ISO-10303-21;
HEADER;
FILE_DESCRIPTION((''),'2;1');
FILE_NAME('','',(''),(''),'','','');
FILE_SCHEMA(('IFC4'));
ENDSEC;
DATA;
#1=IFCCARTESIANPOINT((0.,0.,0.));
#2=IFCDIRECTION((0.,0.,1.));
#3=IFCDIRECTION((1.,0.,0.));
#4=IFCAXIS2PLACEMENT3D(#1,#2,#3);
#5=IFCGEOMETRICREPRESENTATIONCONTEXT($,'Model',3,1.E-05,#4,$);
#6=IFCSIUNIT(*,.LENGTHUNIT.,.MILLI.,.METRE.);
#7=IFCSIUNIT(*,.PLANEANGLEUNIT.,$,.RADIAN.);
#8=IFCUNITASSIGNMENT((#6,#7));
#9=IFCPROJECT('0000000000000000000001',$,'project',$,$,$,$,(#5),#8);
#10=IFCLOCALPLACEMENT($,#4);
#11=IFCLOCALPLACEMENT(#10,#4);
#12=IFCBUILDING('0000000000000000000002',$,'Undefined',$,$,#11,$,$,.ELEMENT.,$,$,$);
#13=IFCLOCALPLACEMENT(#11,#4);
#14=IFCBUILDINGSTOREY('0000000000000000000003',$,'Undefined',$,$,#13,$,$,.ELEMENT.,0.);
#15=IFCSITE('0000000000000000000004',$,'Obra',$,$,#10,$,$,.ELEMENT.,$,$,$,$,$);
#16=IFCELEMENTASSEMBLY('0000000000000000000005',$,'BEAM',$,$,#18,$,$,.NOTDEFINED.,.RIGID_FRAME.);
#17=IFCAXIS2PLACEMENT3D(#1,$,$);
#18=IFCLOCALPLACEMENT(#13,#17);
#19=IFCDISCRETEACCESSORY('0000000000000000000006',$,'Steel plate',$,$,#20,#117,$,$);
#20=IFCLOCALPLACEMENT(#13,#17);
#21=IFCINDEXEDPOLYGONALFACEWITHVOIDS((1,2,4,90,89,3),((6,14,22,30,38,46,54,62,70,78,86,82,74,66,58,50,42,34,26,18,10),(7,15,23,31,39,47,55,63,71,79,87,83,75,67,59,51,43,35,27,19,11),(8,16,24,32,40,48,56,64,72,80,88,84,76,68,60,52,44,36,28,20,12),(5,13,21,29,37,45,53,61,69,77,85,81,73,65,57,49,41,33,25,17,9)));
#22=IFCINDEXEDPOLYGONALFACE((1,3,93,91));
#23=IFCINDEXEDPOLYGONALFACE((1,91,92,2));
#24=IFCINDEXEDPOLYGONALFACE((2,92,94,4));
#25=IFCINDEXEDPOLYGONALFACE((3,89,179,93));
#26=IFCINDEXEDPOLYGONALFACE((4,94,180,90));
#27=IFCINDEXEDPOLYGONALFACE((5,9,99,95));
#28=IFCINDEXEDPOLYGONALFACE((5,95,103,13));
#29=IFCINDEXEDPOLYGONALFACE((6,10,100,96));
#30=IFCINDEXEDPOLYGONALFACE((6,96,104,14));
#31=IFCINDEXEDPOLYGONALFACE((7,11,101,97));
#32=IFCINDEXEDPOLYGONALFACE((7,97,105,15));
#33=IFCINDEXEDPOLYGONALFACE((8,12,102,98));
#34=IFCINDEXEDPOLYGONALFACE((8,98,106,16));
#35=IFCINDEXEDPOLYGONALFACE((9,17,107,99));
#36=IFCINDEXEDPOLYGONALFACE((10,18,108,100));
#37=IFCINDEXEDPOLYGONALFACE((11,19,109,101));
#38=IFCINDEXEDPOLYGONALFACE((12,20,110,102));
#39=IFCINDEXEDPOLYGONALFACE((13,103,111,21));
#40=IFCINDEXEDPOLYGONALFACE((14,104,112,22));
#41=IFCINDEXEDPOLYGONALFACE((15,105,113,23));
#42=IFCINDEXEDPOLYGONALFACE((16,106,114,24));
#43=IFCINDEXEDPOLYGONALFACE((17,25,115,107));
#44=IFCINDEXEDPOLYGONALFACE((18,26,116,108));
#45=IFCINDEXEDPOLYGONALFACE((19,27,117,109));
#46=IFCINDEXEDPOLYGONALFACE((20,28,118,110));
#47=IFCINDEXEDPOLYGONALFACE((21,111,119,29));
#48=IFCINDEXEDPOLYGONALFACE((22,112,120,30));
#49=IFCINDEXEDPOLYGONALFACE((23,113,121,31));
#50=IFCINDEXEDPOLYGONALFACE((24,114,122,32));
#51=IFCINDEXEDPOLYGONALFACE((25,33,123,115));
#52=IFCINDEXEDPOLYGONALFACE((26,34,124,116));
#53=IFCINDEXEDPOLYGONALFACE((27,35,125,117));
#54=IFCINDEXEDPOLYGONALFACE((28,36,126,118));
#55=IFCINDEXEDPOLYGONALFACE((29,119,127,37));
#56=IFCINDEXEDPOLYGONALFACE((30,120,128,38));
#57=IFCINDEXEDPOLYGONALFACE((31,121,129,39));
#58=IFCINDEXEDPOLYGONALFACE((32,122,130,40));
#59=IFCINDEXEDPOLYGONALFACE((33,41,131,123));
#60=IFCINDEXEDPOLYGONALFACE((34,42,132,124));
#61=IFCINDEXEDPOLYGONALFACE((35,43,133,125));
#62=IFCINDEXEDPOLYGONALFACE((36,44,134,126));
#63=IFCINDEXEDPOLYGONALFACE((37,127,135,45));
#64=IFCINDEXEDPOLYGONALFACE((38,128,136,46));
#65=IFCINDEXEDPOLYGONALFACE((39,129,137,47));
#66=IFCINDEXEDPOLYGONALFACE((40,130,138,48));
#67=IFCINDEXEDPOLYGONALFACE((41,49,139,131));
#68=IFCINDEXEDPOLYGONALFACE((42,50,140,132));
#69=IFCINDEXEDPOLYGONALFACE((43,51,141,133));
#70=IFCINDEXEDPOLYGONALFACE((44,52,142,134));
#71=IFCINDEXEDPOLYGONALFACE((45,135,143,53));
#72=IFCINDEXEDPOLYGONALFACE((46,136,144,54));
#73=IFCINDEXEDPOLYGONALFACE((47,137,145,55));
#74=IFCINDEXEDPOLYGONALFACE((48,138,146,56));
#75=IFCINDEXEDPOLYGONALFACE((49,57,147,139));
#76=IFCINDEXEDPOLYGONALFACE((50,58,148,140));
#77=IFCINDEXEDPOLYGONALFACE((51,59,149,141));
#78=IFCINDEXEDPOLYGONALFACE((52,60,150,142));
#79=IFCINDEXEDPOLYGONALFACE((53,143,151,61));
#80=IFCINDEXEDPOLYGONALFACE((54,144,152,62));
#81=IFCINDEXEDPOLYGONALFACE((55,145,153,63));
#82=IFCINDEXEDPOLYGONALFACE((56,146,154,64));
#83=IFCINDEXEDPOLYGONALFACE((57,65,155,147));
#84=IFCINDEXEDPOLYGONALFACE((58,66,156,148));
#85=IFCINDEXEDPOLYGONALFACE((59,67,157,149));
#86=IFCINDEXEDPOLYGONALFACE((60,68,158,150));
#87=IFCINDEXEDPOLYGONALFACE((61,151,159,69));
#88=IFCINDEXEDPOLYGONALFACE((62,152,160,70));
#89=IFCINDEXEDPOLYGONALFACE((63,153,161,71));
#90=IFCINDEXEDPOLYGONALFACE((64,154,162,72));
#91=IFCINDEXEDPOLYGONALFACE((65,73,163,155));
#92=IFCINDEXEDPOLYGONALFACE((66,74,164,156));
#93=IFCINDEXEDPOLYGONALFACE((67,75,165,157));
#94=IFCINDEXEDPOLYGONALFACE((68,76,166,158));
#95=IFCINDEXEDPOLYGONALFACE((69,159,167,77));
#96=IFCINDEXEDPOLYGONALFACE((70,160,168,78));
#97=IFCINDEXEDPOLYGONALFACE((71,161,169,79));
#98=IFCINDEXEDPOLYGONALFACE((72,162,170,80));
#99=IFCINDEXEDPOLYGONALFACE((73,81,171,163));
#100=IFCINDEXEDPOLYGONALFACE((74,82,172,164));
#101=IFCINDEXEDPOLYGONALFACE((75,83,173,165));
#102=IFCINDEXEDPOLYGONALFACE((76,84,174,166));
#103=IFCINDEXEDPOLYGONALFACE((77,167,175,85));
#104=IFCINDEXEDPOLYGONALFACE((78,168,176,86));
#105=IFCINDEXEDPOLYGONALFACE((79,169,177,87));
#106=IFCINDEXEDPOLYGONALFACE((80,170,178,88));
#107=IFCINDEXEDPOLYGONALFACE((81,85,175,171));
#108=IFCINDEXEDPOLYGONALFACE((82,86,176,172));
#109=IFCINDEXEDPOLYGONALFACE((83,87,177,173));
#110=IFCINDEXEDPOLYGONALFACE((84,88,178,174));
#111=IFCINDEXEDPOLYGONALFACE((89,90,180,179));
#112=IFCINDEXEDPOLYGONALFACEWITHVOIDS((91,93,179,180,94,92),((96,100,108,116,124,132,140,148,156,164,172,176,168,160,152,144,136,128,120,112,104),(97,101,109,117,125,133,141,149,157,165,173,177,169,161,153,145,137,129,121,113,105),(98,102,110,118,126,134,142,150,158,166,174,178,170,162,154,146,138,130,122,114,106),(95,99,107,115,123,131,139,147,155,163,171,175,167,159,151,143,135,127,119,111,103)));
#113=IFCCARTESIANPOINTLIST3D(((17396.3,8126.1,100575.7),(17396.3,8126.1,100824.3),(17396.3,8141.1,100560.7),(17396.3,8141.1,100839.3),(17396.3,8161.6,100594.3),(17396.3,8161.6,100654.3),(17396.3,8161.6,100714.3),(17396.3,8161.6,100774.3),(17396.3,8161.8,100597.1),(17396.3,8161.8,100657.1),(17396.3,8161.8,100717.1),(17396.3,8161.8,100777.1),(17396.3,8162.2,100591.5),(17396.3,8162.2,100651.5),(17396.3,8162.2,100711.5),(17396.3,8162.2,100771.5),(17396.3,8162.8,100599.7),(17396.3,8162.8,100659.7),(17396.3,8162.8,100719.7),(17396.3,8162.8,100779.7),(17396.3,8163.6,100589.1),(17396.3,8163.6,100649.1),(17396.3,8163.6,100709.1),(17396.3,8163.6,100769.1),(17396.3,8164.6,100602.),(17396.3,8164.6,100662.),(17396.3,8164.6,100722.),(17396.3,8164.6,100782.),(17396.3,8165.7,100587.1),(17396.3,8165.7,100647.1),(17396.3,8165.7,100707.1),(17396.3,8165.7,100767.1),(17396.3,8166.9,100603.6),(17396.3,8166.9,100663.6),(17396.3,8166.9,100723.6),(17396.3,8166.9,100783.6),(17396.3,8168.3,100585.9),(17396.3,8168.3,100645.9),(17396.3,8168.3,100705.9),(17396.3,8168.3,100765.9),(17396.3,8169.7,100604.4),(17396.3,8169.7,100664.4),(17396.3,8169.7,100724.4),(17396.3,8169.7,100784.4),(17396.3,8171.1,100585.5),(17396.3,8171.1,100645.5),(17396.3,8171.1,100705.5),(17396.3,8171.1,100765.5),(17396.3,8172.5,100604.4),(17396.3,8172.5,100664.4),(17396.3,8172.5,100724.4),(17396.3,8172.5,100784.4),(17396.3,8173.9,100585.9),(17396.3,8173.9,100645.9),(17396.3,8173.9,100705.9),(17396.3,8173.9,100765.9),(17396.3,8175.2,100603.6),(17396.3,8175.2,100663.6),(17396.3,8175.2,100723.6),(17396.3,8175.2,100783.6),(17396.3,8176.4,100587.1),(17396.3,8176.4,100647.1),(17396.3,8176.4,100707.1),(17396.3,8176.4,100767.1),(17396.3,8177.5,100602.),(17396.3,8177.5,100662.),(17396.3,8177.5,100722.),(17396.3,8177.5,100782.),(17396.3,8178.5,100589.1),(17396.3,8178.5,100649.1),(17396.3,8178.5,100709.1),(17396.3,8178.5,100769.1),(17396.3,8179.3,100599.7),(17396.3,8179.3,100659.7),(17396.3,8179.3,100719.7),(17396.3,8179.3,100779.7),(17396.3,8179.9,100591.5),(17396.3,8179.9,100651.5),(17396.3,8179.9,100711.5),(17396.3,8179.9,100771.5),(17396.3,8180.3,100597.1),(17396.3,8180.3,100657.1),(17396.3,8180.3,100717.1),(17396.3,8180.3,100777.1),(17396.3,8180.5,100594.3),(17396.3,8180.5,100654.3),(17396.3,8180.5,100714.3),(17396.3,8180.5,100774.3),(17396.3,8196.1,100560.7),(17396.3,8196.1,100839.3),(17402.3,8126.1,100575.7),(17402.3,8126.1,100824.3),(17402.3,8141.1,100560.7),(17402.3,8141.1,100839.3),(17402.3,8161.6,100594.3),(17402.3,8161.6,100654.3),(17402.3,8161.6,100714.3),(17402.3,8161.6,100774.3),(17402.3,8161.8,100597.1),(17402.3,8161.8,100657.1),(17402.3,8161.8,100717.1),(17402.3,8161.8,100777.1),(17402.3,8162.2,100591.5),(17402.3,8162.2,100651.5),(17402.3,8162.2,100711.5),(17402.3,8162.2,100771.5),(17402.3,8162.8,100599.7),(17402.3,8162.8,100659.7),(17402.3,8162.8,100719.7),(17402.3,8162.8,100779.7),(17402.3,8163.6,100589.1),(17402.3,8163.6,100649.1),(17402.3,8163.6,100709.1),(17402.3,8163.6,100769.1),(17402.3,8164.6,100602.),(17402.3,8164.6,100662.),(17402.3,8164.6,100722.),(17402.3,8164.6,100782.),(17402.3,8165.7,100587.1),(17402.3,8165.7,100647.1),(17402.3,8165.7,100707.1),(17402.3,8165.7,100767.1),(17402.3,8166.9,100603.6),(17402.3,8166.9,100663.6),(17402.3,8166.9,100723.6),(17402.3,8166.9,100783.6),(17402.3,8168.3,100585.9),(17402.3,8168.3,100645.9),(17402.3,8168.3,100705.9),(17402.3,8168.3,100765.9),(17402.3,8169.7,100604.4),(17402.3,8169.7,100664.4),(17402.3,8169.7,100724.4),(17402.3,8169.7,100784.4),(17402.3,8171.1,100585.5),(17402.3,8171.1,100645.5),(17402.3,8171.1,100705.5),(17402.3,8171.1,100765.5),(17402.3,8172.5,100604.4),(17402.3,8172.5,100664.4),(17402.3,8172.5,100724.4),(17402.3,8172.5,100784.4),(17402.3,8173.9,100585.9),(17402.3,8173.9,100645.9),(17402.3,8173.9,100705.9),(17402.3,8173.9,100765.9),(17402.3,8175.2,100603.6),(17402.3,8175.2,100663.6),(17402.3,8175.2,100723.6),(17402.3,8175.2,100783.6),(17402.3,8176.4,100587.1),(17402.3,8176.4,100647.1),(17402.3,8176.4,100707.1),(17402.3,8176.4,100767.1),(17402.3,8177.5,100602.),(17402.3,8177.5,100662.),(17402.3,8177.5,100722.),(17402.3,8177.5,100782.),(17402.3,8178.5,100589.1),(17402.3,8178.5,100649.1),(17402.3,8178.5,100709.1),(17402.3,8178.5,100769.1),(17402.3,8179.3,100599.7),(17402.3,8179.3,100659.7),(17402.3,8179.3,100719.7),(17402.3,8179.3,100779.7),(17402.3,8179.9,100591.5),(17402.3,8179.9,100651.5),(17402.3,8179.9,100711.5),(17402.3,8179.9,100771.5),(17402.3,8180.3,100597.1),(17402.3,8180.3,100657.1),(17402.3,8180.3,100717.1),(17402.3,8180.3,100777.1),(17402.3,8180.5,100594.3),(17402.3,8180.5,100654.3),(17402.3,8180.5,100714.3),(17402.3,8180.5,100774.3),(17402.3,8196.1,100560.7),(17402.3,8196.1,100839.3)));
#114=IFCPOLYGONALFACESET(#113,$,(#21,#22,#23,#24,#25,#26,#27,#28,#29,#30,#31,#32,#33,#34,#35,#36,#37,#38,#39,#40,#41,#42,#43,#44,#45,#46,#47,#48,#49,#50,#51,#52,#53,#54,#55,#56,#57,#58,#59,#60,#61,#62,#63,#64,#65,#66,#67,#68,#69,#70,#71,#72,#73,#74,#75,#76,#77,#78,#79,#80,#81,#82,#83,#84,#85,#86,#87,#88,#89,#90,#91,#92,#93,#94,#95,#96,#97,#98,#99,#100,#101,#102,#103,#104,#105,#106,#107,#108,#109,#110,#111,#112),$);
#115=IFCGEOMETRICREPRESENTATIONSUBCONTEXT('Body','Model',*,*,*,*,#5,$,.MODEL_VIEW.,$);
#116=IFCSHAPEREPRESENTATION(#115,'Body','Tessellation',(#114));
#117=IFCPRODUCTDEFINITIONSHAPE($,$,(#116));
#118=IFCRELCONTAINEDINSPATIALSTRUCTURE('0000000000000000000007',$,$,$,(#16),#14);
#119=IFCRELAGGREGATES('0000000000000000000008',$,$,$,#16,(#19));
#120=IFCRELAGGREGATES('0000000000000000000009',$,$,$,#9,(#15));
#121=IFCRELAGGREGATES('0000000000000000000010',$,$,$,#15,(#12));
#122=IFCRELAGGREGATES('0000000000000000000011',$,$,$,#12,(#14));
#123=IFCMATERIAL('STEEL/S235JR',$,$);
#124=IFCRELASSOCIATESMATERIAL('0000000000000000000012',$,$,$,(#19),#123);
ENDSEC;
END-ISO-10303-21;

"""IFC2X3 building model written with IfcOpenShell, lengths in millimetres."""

from ifc_helpers import new_model, si_unit, frame, origin_with_axes, origin_2d_with_axis, place, context, subcontext, project, spatial, polyline, circle, outline, extrude, source, transform, mapped, material, element, aggregate, save


model = new_model("IFC2X3")

# Units and contexts
model_context = context("Model", 3, precision=1e-05, world=origin_with_axes())
body_context = subcontext(model_context, "Body", "Model", "MODEL_VIEW")
ifc_project = project(units=[si_unit("LENGTHUNIT", "METRE", prefix="MILLI"), si_unit("PLANEANGLEUNIT", "RADIAN")], contexts=[model_context])

# Site, building, storey
site_placement = place(None, origin_with_axes())
site = spatial("IfcSite", under=ifc_project, at=site_placement, Name="Obra", CompositionType="ELEMENT")
building_placement = place(site_placement, origin_with_axes())
building = spatial("IfcBuilding", under=site, at=building_placement, Name="Undefined", CompositionType="ELEMENT")
storey_placement = place(building_placement, origin_with_axes())
storey = spatial("IfcBuildingStorey", under=building, at=storey_placement, Name="Undefined", CompositionType="ELEMENT", Elevation=0.0)

# Element assembly, discrete accessory, opening
ifc_material_1 = material(Name="STEEL/S235JR")
shared_shape_1 = source(origin_with_axes(), body_context, "Body", "SweptSolid", [
    extrude(circle(Radius=9.5, at=origin_2d_with_axis()), frame((0.0, -9.8, 0.0), z_axis=(0.0, 1.0, 0.0), x_axis=(1.0, 0.0, 0.0)), (0.0, 0.0, 1.0), 6.2),
])
assembly_1_placement = place(storey_placement, origin_with_axes())
assembly_1 = element("IfcElementAssembly", 1, at=assembly_1_placement, inside=storey, Name="BEAM", AssemblyPlace="NOTDEFINED", PredefinedType="RIGID_FRAME")
discrete_accessory_1_placement = place(assembly_1_placement, frame((17399.3, 8196.1, 100560.7), z_axis=(-1.0, 0.0, 0.0), x_axis=(0.0, -1.0, 0.0)))
discrete_accessory_1 = element("IfcDiscreteAccessory", 2, at=discrete_accessory_1_placement, material=ifc_material_1, Name="Steel plate", context=body_context, shape_type="SweptSolid", body=[
    extrude(outline(polyline([(0.0, 0.0), (55.0, 0.0), (70.0, 15.0), (70.0, 263.6), (55.0, 278.6), (0.0, 278.6), (0.0, 0.0)])), frame((0.0, 0.0, -3.0), z_axis=(0.0, 0.0, 1.0), x_axis=(1.0, 0.0, 0.0)), (0.0, 0.0, 1.0), 6.0),
])
opening_1_placement = place(assembly_1_placement, frame((17392.6, 8136.1, 100850.0), z_axis=(0.0, 1.0, 0.0), x_axis=(0.0, 0.0, -1.0)))
element("IfcOpeningElement", 3, at=opening_1_placement, cuts=discrete_accessory_1, ObjectType="Opening", context=body_context, shape_type="MappedRepresentation", body=[
    mapped(shared_shape_1, transform((75.0, 0.0, 35.0))),
    mapped(shared_shape_1, transform((135.0, 0.0, 35.0))),
    mapped(shared_shape_1, transform((195.0, 0.0, 35.0))),
    mapped(shared_shape_1, transform((255.0, 0.0, 35.0))),
])

aggregate(assembly_1, [discrete_accessory_1])

save(model, "model.ifc")
